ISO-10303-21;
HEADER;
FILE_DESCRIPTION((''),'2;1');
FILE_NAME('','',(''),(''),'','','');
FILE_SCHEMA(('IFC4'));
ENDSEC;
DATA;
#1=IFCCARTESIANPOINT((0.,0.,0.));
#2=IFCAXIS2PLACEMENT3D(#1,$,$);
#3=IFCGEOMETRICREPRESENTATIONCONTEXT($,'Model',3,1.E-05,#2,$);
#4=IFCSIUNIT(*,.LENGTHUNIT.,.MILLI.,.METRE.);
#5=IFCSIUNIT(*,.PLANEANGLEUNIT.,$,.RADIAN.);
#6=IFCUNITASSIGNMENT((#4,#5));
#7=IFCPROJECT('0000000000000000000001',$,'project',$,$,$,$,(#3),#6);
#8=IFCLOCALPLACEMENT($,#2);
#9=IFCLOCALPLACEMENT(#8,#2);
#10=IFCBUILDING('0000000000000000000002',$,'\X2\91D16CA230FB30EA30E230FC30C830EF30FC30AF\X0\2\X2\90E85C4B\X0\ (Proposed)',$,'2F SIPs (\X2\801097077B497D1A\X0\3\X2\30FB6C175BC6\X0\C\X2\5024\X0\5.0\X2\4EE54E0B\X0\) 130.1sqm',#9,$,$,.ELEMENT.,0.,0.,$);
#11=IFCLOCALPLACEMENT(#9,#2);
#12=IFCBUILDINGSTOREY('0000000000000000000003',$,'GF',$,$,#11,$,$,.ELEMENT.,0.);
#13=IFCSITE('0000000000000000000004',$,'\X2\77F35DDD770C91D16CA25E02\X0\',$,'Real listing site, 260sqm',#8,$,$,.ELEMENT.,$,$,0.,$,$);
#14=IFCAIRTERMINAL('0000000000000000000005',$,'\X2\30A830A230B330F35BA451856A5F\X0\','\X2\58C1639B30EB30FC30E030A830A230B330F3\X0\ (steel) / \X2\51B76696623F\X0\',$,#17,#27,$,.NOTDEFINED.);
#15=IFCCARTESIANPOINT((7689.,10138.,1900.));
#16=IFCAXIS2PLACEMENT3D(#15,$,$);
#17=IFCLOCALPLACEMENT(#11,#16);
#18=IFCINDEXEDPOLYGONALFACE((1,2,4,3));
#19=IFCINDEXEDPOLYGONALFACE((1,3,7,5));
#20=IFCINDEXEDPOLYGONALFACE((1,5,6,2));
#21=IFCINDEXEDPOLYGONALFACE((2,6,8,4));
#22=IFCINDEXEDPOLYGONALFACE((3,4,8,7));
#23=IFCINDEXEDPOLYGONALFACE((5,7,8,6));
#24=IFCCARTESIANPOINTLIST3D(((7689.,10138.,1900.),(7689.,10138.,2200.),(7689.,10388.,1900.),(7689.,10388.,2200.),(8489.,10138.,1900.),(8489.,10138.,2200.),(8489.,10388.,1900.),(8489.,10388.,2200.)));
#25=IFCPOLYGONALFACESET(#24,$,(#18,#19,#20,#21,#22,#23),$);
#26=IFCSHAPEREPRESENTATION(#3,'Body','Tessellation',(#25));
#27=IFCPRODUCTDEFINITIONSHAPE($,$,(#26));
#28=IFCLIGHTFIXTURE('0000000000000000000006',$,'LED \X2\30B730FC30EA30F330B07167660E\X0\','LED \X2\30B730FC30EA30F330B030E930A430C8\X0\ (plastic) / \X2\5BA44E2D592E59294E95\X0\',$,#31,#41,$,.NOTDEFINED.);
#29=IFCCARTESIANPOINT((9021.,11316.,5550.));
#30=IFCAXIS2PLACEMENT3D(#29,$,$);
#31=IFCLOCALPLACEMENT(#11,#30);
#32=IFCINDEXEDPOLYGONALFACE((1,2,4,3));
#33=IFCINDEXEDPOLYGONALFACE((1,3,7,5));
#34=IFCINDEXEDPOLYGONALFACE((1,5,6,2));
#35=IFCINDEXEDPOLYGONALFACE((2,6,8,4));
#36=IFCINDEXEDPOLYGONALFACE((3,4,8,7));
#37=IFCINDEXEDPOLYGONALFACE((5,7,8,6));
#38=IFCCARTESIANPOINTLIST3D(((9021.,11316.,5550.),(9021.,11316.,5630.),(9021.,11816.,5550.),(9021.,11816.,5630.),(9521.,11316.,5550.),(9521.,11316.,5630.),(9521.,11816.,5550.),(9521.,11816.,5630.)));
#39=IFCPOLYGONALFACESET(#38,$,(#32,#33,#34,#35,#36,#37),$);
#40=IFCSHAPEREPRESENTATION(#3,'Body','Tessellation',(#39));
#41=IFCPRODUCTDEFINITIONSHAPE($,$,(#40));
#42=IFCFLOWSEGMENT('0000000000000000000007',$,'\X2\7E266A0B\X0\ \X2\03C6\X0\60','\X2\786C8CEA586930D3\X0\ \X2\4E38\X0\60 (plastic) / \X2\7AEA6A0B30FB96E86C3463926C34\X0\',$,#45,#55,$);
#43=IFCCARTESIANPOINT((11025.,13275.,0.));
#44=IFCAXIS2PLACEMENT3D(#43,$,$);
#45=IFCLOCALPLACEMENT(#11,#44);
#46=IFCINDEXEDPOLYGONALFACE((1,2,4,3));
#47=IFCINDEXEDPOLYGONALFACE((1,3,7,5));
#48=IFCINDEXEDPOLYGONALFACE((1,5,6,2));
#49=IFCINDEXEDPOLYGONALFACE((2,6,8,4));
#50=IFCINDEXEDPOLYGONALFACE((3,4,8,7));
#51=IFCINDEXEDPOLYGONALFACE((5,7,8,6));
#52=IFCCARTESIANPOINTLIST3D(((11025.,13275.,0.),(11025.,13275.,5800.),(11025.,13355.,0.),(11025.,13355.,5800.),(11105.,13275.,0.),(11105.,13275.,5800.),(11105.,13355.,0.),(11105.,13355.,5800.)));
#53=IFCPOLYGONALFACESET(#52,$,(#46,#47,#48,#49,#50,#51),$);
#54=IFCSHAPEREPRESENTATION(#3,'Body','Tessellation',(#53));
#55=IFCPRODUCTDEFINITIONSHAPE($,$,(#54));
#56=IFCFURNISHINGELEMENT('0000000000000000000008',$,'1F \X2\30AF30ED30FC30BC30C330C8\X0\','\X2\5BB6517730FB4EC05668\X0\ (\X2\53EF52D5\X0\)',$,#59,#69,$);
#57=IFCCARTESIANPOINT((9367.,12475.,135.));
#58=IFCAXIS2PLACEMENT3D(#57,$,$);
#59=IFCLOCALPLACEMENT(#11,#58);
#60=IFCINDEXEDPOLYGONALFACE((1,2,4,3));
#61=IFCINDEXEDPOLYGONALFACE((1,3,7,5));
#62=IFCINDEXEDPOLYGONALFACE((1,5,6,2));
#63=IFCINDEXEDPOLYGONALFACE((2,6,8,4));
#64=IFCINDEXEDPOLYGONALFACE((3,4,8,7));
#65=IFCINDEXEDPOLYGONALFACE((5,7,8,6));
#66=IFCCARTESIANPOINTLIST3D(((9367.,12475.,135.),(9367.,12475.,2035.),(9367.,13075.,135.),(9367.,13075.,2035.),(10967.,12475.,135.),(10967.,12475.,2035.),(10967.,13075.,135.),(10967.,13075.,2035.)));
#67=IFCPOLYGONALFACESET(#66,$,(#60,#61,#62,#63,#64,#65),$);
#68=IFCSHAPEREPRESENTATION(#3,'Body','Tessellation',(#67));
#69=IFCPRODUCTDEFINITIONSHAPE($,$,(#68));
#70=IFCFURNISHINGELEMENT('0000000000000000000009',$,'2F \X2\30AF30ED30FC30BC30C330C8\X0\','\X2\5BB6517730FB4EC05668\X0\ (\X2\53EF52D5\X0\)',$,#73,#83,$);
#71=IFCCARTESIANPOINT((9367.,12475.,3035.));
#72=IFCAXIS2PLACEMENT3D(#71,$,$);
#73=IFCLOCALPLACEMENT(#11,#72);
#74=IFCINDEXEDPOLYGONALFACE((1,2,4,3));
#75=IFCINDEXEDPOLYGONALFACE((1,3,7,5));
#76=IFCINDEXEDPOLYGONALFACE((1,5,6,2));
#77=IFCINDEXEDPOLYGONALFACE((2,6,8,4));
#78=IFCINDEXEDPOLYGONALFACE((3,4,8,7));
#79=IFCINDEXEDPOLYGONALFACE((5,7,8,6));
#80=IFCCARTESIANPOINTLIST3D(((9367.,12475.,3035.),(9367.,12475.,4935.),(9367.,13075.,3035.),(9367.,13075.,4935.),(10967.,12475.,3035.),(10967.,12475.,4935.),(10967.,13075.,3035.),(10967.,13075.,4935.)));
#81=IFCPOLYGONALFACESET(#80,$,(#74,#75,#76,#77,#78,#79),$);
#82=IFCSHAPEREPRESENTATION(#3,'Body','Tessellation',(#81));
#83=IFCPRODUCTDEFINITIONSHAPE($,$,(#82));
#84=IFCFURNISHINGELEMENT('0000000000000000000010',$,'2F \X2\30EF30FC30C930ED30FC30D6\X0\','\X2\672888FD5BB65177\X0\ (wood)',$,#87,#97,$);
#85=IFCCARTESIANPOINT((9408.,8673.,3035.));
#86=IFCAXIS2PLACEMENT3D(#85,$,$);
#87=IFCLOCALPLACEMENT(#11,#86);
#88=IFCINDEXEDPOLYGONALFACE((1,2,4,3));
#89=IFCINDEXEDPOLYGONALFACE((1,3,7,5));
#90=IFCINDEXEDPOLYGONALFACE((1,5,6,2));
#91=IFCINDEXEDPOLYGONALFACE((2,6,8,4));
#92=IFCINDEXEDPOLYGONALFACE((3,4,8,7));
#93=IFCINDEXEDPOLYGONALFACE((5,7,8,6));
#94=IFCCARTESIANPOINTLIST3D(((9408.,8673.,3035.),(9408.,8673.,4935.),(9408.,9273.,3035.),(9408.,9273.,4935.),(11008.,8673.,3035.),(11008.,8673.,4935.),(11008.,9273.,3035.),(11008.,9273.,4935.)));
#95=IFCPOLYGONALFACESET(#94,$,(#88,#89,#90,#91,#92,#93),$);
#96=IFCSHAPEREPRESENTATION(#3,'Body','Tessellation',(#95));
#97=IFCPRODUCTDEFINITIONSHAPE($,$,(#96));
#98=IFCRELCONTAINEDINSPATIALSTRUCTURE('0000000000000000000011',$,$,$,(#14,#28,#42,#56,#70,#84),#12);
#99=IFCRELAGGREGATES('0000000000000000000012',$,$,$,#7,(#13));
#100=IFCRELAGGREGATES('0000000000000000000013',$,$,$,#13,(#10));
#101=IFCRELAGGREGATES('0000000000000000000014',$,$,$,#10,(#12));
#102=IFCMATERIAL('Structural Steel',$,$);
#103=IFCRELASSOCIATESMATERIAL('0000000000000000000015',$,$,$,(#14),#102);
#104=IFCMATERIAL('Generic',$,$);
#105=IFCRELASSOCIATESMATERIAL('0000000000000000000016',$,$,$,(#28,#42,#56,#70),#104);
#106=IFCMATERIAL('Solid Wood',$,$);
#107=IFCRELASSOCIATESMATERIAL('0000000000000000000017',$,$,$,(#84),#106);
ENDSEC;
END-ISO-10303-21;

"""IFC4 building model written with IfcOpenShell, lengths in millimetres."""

from ifc_helpers import new_model, si_unit, frame, frame_2d, origin, place, context, project, spatial, rectangle, extrude, material, element, save


model = new_model("IFC4")

# Units and contexts
model_context = context("Model", 3, precision=1e-05, world=origin())
ifc_project = project(units=[si_unit("LENGTHUNIT", "METRE", prefix="MILLI"), si_unit("PLANEANGLEUNIT", "RADIAN")], contexts=[model_context])

# Site, building, storey
site_placement = place(None, origin())
site = spatial("IfcSite", under=ifc_project, at=site_placement, Name="石川県金沢市", ObjectType="Real listing site, 260sqm", CompositionType="ELEMENT", RefElevation=0.0)
building_placement = place(site_placement, origin())
building = spatial("IfcBuilding", under=site, at=building_placement, Name="金沢・リモートワーク2部屋 (Proposed)", ObjectType="2F SIPs (耐震等級3・気密C値5.0以下) 130.1sqm", CompositionType="ELEMENT", ElevationOfRefHeight=0.0, ElevationOfTerrain=0.0)
storey_placement = place(building_placement, origin())
storey = spatial("IfcBuildingStorey", under=building, at=storey_placement, Name="GF", CompositionType="ELEMENT", Elevation=0.0)

# Shared definitions
ifc_material_1 = material(Name="Solid Wood")

# Shared definitions
ifc_material_2 = material(Name="Structural Steel")

# Shared definitions
ifc_material_3 = material(Name="Generic")

# Air terminal
air_terminal_placement = place(storey_placement, frame((7689.0, 10138.0, 1900.0)))
element("IfcAirTerminal", 1, at=air_terminal_placement, inside=storey, material=ifc_material_2, Name="エアコン室内機", Description="壁掛ルームエアコン (steel) / 冷暖房", PredefinedType="NOTDEFINED", context=model_context, shape_type="SweptSolid", body=[
    extrude(rectangle(XDim=800.0, YDim=250.0, at=frame_2d((400.0, 125.0))), frame((7689.0, 10138.0, 1900.0)), (0.0, 0.0, 1.0), 300.0),
])

# Light fixture
light_fixture_1_placement = place(storey_placement, frame((9021.0, 11316.0, 5550.0)))
element("IfcLightFixture", 2, at=light_fixture_1_placement, inside=storey, material=ifc_material_3, Name="LED シーリング照明", Description="LED シーリングライト (plastic) / 室中央天井", PredefinedType="NOTDEFINED", context=model_context, shape_type="SweptSolid", body=[
    extrude(rectangle(XDim=500.0, YDim=500.0, at=frame_2d((250.0, 250.0))), frame((9021.0, 11316.0, 5550.0)), (0.0, 0.0, 1.0), 80.0),
])

# Flow segment
flow_segment_placement = place(storey_placement, frame((11025.0, 13275.0, 0.0)))
element("IfcFlowSegment", 3, at=flow_segment_placement, inside=storey, material=ifc_material_3, Name="縦樋 φ60", Description="硬質塩ビ 丸60 (plastic) / 竪樋・雨水排水", context=model_context, shape_type="SweptSolid", body=[
    extrude(rectangle(XDim=80.0, YDim=80.0, at=frame_2d((40.0, 40.0))), frame((11025.0, 13275.0, 0.0)), (0.0, 0.0, 1.0), 5800.0),
])

# Furnishing elements
furnishing_1_placement = place(storey_placement, frame((9367.0, 12475.0, 135.0)))
element("IfcFurnishingElement", 4, at=furnishing_1_placement, inside=storey, material=ifc_material_3, Name="1F クローゼット", Description="家具・什器 (可動)", context=model_context, shape_type="SweptSolid", body=[
    extrude(rectangle(XDim=1600.0, YDim=600.0, at=frame_2d((800.0, 300.0))), frame((9367.0, 12475.0, 135.0)), (0.0, 0.0, 1.0), 1900.0),
])
furnishing_2_placement = place(storey_placement, frame((9367.0, 12475.0, 3035.0)))
element("IfcFurnishingElement", 5, at=furnishing_2_placement, inside=storey, material=ifc_material_3, Name="2F クローゼット", Description="家具・什器 (可動)", context=model_context, shape_type="SweptSolid", body=[
    extrude(rectangle(XDim=1600.0, YDim=600.0, at=frame_2d((800.0, 300.0))), frame((9367.0, 12475.0, 3035.0)), (0.0, 0.0, 1.0), 1900.0),
])
furnishing_3_placement = place(storey_placement, frame((9408.0, 8673.0, 3035.0)))
element("IfcFurnishingElement", 6, at=furnishing_3_placement, inside=storey, material=ifc_material_1, Name="2F ワードローブ", Description="木製家具 (wood)", context=model_context, shape_type="SweptSolid", body=[
    extrude(rectangle(XDim=1600.0, YDim=600.0, at=frame_2d((800.0, 300.0))), frame((9408.0, 8673.0, 3035.0)), (0.0, 0.0, 1.0), 1900.0),
])

save(model, "model.ifc")
